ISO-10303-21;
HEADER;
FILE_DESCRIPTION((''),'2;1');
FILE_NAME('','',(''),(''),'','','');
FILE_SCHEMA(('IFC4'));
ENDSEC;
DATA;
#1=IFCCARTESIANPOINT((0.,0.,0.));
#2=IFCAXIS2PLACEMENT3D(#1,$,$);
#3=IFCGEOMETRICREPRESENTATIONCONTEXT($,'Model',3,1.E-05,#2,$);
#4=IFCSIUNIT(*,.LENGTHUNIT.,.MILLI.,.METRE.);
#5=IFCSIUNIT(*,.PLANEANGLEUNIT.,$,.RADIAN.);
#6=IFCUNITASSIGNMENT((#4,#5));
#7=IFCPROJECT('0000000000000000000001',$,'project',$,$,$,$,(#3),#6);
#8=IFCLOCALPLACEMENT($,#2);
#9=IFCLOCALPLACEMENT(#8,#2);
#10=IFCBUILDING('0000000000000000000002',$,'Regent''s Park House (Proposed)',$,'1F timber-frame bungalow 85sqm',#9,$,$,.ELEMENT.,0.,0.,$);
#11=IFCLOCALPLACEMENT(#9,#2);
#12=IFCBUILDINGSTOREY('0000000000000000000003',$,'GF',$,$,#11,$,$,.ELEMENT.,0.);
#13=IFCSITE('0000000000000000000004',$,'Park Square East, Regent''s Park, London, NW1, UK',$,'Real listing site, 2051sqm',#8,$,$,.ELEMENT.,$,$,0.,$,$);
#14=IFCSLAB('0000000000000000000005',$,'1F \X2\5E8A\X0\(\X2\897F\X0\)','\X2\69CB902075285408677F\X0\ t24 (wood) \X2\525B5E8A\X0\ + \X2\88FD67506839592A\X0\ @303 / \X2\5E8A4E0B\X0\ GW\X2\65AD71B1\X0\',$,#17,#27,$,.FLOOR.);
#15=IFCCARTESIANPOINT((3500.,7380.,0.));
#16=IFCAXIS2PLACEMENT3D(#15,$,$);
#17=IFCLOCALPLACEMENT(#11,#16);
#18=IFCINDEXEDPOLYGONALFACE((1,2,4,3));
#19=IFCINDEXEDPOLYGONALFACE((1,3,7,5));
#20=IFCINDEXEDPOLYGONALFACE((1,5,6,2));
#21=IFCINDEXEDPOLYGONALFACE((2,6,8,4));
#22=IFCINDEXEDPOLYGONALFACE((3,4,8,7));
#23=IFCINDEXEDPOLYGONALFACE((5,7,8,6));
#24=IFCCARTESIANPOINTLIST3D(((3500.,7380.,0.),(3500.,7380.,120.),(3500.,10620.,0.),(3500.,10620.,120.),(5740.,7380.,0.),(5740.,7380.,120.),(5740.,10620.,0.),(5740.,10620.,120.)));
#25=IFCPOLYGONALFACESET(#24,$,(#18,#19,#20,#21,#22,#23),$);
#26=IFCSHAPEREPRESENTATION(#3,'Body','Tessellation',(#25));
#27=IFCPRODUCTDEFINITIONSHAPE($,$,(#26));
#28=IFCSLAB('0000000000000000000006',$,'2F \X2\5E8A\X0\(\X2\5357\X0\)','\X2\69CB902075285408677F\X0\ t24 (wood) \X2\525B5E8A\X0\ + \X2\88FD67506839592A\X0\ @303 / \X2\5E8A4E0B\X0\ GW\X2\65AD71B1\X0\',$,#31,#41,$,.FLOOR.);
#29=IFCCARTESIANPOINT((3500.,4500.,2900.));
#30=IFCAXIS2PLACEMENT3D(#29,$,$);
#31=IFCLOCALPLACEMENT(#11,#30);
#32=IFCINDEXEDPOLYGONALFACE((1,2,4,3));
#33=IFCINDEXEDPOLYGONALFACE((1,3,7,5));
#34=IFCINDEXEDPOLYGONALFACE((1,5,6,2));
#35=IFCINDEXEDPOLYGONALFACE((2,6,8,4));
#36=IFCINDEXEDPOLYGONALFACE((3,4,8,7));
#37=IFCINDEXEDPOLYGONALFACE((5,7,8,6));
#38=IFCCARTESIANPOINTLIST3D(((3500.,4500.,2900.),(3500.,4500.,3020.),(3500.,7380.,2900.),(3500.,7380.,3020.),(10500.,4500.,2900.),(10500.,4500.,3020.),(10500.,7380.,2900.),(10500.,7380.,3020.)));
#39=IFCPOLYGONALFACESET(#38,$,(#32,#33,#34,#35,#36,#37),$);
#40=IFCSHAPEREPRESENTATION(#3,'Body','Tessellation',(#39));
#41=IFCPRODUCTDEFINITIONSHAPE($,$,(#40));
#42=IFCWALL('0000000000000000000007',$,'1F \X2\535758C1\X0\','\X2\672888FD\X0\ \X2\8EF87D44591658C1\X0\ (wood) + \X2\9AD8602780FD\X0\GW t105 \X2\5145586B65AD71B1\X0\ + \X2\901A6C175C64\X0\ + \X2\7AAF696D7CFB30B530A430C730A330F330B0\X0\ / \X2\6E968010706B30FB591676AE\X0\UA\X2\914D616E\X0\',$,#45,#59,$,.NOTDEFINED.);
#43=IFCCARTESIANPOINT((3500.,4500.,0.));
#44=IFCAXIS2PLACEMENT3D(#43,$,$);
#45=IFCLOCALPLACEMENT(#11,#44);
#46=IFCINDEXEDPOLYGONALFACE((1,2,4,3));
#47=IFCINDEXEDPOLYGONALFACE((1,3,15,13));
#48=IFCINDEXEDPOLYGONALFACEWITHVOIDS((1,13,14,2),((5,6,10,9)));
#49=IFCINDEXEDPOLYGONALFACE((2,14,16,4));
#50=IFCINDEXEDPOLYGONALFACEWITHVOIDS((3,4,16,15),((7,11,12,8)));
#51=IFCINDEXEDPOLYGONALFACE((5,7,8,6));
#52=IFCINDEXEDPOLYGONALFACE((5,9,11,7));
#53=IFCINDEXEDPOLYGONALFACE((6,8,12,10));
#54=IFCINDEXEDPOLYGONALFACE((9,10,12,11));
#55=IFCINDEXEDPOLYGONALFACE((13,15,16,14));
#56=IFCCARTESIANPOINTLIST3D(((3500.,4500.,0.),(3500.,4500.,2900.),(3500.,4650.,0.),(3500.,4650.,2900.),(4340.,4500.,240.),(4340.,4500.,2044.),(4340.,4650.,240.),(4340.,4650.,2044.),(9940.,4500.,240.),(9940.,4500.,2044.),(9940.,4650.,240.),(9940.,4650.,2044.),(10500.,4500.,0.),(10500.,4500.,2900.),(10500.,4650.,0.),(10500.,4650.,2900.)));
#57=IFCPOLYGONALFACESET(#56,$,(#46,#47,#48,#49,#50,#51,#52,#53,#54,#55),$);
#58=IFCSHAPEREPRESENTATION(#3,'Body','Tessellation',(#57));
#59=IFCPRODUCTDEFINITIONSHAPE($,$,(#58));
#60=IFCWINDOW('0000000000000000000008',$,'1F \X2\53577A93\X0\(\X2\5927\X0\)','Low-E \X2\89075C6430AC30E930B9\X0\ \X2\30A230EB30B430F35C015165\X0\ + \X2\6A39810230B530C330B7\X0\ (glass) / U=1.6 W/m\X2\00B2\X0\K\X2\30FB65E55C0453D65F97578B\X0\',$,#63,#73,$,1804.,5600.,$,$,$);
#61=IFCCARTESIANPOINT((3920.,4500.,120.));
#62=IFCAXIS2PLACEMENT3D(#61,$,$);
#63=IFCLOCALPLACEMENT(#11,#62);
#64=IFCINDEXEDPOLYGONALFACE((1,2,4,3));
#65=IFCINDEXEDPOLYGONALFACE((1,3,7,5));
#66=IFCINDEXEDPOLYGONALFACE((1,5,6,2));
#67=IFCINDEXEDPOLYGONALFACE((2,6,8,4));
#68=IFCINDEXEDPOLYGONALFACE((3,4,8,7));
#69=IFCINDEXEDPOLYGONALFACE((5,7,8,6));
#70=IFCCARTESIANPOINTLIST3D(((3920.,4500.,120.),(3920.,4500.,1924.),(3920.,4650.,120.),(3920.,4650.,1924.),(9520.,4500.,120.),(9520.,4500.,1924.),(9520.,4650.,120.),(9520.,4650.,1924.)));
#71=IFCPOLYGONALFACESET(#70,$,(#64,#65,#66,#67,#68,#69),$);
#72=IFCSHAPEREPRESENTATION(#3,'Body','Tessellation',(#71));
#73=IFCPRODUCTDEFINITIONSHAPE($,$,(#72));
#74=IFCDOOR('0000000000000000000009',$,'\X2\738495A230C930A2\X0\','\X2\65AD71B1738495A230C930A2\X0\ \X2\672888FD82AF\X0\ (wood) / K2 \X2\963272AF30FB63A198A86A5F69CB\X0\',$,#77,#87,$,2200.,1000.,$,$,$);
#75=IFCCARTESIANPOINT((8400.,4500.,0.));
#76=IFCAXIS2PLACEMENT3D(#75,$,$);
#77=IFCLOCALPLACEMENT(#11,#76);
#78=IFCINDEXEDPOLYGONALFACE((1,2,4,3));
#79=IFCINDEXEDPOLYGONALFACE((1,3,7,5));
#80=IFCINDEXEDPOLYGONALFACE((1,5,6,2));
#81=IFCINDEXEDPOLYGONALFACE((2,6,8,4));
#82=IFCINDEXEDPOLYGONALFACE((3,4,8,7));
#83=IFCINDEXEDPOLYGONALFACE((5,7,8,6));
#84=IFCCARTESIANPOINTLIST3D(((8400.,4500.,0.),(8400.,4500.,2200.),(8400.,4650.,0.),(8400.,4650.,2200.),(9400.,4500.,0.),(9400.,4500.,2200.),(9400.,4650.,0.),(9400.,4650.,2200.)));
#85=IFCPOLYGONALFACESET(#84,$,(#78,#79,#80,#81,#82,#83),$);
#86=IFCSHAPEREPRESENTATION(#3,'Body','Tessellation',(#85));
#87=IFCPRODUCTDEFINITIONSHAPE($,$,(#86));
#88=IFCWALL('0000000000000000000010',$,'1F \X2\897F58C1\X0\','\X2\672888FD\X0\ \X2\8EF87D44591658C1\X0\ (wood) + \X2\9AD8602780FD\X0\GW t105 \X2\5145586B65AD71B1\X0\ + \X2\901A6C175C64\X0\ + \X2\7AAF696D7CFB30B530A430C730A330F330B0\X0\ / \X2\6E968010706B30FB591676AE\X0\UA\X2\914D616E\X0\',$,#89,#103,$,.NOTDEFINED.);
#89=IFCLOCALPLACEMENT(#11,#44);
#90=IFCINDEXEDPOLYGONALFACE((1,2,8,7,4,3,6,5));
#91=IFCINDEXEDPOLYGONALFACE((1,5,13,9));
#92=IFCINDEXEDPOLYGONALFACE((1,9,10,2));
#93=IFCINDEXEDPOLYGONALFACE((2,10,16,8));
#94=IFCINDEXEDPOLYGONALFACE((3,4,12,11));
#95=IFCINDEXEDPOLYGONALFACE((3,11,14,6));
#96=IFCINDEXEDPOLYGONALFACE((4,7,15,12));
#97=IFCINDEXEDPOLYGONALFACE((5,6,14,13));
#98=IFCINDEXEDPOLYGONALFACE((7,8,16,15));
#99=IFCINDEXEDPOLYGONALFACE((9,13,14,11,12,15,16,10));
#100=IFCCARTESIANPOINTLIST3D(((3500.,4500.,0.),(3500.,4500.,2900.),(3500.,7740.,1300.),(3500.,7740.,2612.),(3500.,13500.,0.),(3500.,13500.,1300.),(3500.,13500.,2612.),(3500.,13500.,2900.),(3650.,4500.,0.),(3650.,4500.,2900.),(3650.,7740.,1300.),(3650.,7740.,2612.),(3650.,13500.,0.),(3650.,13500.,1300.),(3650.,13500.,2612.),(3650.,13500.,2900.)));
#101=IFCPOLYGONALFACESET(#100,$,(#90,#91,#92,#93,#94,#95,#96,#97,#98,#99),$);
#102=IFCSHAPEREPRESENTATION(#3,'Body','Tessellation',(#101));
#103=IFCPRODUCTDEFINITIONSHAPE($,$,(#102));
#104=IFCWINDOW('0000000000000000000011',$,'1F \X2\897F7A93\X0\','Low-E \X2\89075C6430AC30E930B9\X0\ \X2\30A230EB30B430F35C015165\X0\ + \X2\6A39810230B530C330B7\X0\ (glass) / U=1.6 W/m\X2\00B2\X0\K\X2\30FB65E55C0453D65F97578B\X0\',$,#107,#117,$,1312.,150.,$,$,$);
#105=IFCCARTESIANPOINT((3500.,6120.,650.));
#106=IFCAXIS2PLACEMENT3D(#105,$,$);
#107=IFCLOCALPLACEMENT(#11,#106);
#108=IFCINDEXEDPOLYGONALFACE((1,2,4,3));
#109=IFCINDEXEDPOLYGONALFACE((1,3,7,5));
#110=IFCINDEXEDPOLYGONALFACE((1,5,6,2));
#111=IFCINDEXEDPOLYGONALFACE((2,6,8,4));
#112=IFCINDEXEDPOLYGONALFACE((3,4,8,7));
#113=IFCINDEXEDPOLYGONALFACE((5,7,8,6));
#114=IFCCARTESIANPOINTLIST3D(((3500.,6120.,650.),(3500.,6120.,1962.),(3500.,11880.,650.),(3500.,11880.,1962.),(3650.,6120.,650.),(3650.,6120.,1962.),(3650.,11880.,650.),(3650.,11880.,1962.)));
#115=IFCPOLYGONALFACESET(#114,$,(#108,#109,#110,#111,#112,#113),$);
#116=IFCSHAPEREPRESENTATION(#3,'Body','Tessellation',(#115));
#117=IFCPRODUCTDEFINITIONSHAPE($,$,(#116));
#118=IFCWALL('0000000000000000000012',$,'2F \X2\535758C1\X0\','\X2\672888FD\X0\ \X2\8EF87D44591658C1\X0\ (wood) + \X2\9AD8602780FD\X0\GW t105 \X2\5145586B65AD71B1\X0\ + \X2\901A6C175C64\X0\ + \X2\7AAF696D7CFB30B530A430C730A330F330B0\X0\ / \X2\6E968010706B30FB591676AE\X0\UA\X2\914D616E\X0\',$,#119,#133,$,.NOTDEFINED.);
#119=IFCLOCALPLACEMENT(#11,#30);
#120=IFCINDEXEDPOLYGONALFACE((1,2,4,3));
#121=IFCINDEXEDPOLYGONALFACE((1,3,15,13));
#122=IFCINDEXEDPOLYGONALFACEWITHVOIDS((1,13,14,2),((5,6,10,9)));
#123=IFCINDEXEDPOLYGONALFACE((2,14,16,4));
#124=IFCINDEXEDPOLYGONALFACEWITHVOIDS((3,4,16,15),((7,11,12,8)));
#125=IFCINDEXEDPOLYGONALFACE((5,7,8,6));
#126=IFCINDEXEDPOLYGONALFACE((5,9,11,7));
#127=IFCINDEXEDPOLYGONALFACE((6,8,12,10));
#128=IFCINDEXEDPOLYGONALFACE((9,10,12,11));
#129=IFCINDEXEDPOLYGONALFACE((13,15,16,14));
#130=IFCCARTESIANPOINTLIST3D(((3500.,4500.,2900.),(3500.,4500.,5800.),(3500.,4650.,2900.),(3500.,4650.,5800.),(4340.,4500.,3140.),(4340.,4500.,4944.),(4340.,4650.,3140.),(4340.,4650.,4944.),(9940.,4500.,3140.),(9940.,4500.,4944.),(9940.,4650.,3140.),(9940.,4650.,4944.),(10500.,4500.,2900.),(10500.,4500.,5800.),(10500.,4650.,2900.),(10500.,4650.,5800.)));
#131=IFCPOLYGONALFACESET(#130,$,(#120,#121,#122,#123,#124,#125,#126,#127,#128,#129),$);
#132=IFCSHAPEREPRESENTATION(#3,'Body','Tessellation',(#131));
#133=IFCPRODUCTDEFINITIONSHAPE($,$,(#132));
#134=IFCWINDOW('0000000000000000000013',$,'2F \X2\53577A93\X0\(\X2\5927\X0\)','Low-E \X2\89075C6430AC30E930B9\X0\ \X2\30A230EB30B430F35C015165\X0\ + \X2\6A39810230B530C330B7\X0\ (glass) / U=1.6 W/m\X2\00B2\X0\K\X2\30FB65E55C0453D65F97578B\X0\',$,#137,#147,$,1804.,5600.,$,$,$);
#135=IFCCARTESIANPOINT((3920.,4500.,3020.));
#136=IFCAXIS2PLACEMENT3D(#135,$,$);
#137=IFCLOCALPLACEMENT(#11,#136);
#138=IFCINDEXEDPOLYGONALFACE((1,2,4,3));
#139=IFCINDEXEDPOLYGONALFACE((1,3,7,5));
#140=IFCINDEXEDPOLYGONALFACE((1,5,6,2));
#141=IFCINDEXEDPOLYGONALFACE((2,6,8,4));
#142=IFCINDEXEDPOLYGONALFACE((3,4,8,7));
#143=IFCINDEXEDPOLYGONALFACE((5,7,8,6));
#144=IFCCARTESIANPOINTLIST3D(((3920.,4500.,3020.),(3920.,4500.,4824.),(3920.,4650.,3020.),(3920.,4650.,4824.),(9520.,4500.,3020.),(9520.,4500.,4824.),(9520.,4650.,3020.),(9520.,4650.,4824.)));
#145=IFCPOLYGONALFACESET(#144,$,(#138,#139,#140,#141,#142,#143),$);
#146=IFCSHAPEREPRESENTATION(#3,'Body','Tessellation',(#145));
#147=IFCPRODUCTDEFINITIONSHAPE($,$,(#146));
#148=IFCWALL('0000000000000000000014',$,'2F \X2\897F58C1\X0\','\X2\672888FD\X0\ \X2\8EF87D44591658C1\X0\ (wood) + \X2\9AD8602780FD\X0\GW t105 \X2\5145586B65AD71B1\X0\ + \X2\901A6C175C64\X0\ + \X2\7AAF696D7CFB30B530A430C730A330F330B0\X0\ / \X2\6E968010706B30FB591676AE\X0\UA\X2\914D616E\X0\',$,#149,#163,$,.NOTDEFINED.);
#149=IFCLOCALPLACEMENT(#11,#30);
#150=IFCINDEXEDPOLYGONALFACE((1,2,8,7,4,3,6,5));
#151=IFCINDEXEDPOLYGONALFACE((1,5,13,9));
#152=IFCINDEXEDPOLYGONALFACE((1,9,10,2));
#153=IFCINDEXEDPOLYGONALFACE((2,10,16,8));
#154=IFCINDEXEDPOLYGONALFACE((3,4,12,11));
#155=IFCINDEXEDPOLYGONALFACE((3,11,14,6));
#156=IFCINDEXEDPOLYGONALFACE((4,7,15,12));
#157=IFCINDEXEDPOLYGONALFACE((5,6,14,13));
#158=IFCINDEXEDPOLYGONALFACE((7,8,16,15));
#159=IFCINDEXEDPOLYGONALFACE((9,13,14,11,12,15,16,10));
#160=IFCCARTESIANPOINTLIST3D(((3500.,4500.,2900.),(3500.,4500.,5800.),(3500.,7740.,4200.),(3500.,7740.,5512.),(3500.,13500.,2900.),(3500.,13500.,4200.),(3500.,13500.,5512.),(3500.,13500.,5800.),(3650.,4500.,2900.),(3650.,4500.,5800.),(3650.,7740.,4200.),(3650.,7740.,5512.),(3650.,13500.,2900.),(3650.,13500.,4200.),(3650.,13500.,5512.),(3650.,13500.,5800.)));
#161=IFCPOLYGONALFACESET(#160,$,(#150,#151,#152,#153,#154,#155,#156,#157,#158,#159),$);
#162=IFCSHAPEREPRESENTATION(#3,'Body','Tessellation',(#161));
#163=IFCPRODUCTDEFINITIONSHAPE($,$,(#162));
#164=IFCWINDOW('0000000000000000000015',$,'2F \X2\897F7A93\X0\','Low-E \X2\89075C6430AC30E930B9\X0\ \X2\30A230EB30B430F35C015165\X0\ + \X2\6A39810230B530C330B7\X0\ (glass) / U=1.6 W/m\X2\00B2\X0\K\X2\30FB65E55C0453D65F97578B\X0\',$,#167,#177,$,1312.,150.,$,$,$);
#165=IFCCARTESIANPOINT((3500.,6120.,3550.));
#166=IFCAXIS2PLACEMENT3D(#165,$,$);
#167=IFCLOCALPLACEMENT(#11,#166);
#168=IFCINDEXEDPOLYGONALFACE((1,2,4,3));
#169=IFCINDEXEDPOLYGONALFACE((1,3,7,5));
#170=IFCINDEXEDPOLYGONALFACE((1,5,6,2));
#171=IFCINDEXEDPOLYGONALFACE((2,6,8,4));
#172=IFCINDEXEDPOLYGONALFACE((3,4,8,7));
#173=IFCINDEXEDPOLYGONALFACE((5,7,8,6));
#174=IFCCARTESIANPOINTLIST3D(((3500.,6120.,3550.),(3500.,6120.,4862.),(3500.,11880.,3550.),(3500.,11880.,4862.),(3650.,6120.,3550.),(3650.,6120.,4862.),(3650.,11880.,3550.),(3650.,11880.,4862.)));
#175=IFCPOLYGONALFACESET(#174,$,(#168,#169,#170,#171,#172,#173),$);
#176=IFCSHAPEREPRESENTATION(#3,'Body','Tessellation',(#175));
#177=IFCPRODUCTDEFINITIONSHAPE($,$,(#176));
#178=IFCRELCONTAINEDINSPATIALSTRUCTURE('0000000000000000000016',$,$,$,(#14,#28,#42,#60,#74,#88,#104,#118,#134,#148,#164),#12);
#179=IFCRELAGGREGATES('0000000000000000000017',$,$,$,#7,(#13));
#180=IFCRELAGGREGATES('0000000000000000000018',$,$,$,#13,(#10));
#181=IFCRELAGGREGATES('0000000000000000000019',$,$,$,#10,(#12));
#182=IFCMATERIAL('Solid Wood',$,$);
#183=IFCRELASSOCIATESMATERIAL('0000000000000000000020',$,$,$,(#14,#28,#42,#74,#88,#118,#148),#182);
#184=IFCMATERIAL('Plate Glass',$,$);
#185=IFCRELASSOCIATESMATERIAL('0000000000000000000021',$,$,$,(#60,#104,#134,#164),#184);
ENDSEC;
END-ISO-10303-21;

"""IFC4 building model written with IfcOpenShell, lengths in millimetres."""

from ifc_helpers import new_model, si_unit, frame, frame_2d, origin, place, context, project, spatial, rectangle, extrude, material, element, fill, save


model = new_model("IFC4")

# Units and contexts
model_context = context("Model", 3, precision=1e-05, world=origin())
ifc_project = project(units=[si_unit("LENGTHUNIT", "METRE", prefix="MILLI"), si_unit("PLANEANGLEUNIT", "RADIAN")], contexts=[model_context])

# Site, building, storey
site_placement = place(None, origin())
site = spatial("IfcSite", under=ifc_project, at=site_placement, Name="Park Square East, Regent's Park, London, NW1, UK", ObjectType="Real listing site, 2051sqm", CompositionType="ELEMENT", RefElevation=0.0)
building_placement = place(site_placement, origin())
building = spatial("IfcBuilding", under=site, at=building_placement, Name="Regent's Park House (Proposed)", ObjectType="1F timber-frame bungalow 85sqm", CompositionType="ELEMENT", ElevationOfRefHeight=0.0, ElevationOfTerrain=0.0)
storey_placement = place(building_placement, origin())
storey = spatial("IfcBuildingStorey", under=building, at=storey_placement, Name="GF", CompositionType="ELEMENT", Elevation=0.0)

# Slabs
ifc_material_1 = material(Name="Solid Wood")
slab_1_placement = place(storey_placement, frame((3500.0, 7380.0, 0.0)))
element("IfcSlab", 1, at=slab_1_placement, inside=storey, material=ifc_material_1, Name="1F 床(西)", Description="構造用合板 t24 (wood) 剛床 + 製材根太 @303 / 床下 GW断熱", PredefinedType="FLOOR", context=model_context, shape_type="SweptSolid", body=[
    extrude(rectangle(XDim=2240.0, YDim=3240.0, at=frame_2d((1120.0, 1620.0))), frame((3500.0, 7380.0, 0.0)), (0.0, 0.0, 1.0), 120.0),
])
slab_2_placement = place(storey_placement, frame((3500.0, 4500.0, 2900.0)))
element("IfcSlab", 2, at=slab_2_placement, inside=storey, material=ifc_material_1, Name="2F 床(南)", Description="構造用合板 t24 (wood) 剛床 + 製材根太 @303 / 床下 GW断熱", PredefinedType="FLOOR", context=model_context, shape_type="SweptSolid", body=[
    extrude(rectangle(XDim=7000.0, YDim=2880.0, at=frame_2d((3500.0, 1440.0))), frame((3500.0, 4500.0, 2900.0)), (0.0, 0.0, 1.0), 120.0),
])

# Wall, openings, window, door
wall_1_placement = place(storey_placement, frame((3500.0, 4500.0, 0.0)))
wall_1 = element("IfcWall", 3, at=wall_1_placement, inside=storey, material=ifc_material_1, Name="1F 南壁", Description="木製 軸組外壁 (wood) + 高性能GW t105 充填断熱 + 通気層 + 窯業系サイディング / 準耐火・外皮UA配慮", PredefinedType="NOTDEFINED", context=model_context, shape_type="SweptSolid", body=[
    extrude(rectangle(XDim=7000.0, YDim=150.0, at=frame_2d((3500.0, 75.0))), frame((3500.0, 4500.0, 0.0)), (0.0, 0.0, 1.0), 2900.0),
])
opening_1_placement = place(storey_placement, frame((3920.0, 4500.0, 120.0)))
opening_1 = element("IfcOpeningElement", 4, at=opening_1_placement, cuts=wall_1, PredefinedType="NOTDEFINED", context=model_context, shape_type="SweptSolid", body=[
    extrude(rectangle(XDim=5600.0, YDim=150.0, at=frame_2d((2800.0, 75.0))), frame((3920.0, 4500.0, 120.0)), (0.0, 0.0, 1.0), 1804.0),
])
opening_2_placement = place(storey_placement, frame((8400.0, 4500.0, 0.0)))
opening_2 = element("IfcOpeningElement", 5, at=opening_2_placement, cuts=wall_1, PredefinedType="NOTDEFINED", context=model_context, shape_type="SweptSolid", body=[
    extrude(rectangle(XDim=1000.0, YDim=150.0, at=frame_2d((500.0, 75.0))), frame((8400.0, 4500.0, 0.0)), (0.0, 0.0, 1.0), 2200.0),
])
ifc_material_2 = material(Name="Plate Glass")
window_1_placement = place(storey_placement, frame((3920.0, 4500.0, 120.0)))
window_1 = element("IfcWindow", 6, at=window_1_placement, inside=storey, material=ifc_material_2, Name="1F 南窓(大)", Description="Low-E 複層ガラス アルゴン封入 + 樹脂サッシ (glass) / U=1.6 W/m²K・日射取得型", OverallHeight=1804.0, OverallWidth=5600.0, context=model_context, shape_type="SweptSolid", body=[
    extrude(rectangle(XDim=5600.0, YDim=150.0, at=frame_2d((2800.0, 75.0))), frame((3920.0, 4500.0, 120.0)), (0.0, 0.0, 1.0), 1804.0),
])
fill(opening_1, window_1)
door_placement = place(storey_placement, frame((8400.0, 4500.0, 0.0)))
door = element("IfcDoor", 7, at=door_placement, inside=storey, material=ifc_material_1, Name="玄関ドア", Description="断熱玄関ドア 木製芯 (wood) / K2 防犯・採風機構", OverallHeight=2200.0, OverallWidth=1000.0, context=model_context, shape_type="SweptSolid", body=[
    extrude(rectangle(XDim=1000.0, YDim=150.0, at=frame_2d((500.0, 75.0))), frame((8400.0, 4500.0, 0.0)), (0.0, 0.0, 1.0), 2200.0),
])
fill(opening_2, door)

# Walls, openings, windows
wall_2_placement = place(storey_placement, frame((3500.0, 4500.0, 0.0)))
wall_2 = element("IfcWall", 8, at=wall_2_placement, inside=storey, material=ifc_material_1, Name="1F 西壁", Description="木製 軸組外壁 (wood) + 高性能GW t105 充填断熱 + 通気層 + 窯業系サイディング / 準耐火・外皮UA配慮", PredefinedType="NOTDEFINED", context=model_context, shape_type="SweptSolid", body=[
    extrude(rectangle(XDim=150.0, YDim=9000.0, at=frame_2d((75.0, 4500.0))), frame((3500.0, 4500.0, 0.0)), (0.0, 0.0, 1.0), 2900.0),
])
opening_3_placement = place(storey_placement, frame((3500.0, 6120.0, 650.0)))
opening_3 = element("IfcOpeningElement", 9, at=opening_3_placement, cuts=wall_2, PredefinedType="NOTDEFINED", context=model_context, shape_type="SweptSolid", body=[
    extrude(rectangle(XDim=150.0, YDim=5760.0, at=frame_2d((75.0, 2880.0))), frame((3500.0, 6120.0, 650.0)), (0.0, 0.0, 1.0), 1312.0),
])
window_2_placement = place(storey_placement, frame((3500.0, 6120.0, 650.0)))
window_2 = element("IfcWindow", 10, at=window_2_placement, inside=storey, material=ifc_material_2, Name="1F 西窓", Description="Low-E 複層ガラス アルゴン封入 + 樹脂サッシ (glass) / U=1.6 W/m²K・日射取得型", OverallHeight=1312.0, OverallWidth=150.0, context=model_context, shape_type="SweptSolid", body=[
    extrude(rectangle(XDim=150.0, YDim=5760.0, at=frame_2d((75.0, 2880.0))), frame((3500.0, 6120.0, 650.0)), (0.0, 0.0, 1.0), 1312.0),
])
fill(opening_3, window_2)
wall_3_placement = place(storey_placement, frame((3500.0, 4500.0, 2900.0)))
wall_3 = element("IfcWall", 11, at=wall_3_placement, inside=storey, material=ifc_material_1, Name="2F 南壁", Description="木製 軸組外壁 (wood) + 高性能GW t105 充填断熱 + 通気層 + 窯業系サイディング / 準耐火・外皮UA配慮", PredefinedType="NOTDEFINED", context=model_context, shape_type="SweptSolid", body=[
    extrude(rectangle(XDim=7000.0, YDim=150.0, at=frame_2d((3500.0, 75.0))), frame((3500.0, 4500.0, 2900.0)), (0.0, 0.0, 1.0), 2900.0),
])
opening_4_placement = place(storey_placement, frame((3920.0, 4500.0, 3020.0)))
opening_4 = element("IfcOpeningElement", 12, at=opening_4_placement, cuts=wall_3, PredefinedType="NOTDEFINED", context=model_context, shape_type="SweptSolid", body=[
    extrude(rectangle(XDim=5600.0, YDim=150.0, at=frame_2d((2800.0, 75.0))), frame((3920.0, 4500.0, 3020.0)), (0.0, 0.0, 1.0), 1804.0),
])
window_3_placement = place(storey_placement, frame((3920.0, 4500.0, 3020.0)))
window_3 = element("IfcWindow", 13, at=window_3_placement, inside=storey, material=ifc_material_2, Name="2F 南窓(大)", Description="Low-E 複層ガラス アルゴン封入 + 樹脂サッシ (glass) / U=1.6 W/m²K・日射取得型", OverallHeight=1804.0, OverallWidth=5600.0, context=model_context, shape_type="SweptSolid", body=[
    extrude(rectangle(XDim=5600.0, YDim=150.0, at=frame_2d((2800.0, 75.0))), frame((3920.0, 4500.0, 3020.0)), (0.0, 0.0, 1.0), 1804.0),
])
fill(opening_4, window_3)
wall_4_placement = place(storey_placement, frame((3500.0, 4500.0, 2900.0)))
wall_4 = element("IfcWall", 14, at=wall_4_placement, inside=storey, material=ifc_material_1, Name="2F 西壁", Description="木製 軸組外壁 (wood) + 高性能GW t105 充填断熱 + 通気層 + 窯業系サイディング / 準耐火・外皮UA配慮", PredefinedType="NOTDEFINED", context=model_context, shape_type="SweptSolid", body=[
    extrude(rectangle(XDim=150.0, YDim=9000.0, at=frame_2d((75.0, 4500.0))), frame((3500.0, 4500.0, 2900.0)), (0.0, 0.0, 1.0), 2900.0),
])
opening_5_placement = place(storey_placement, frame((3500.0, 6120.0, 3550.0)))
opening_5 = element("IfcOpeningElement", 15, at=opening_5_placement, cuts=wall_4, PredefinedType="NOTDEFINED", context=model_context, shape_type="SweptSolid", body=[
    extrude(rectangle(XDim=150.0, YDim=5760.0, at=frame_2d((75.0, 2880.0))), frame((3500.0, 6120.0, 3550.0)), (0.0, 0.0, 1.0), 1312.0),
])
window_4_placement = place(storey_placement, frame((3500.0, 6120.0, 3550.0)))
window_4 = element("IfcWindow", 16, at=window_4_placement, inside=storey, material=ifc_material_2, Name="2F 西窓", Description="Low-E 複層ガラス アルゴン封入 + 樹脂サッシ (glass) / U=1.6 W/m²K・日射取得型", OverallHeight=1312.0, OverallWidth=150.0, context=model_context, shape_type="SweptSolid", body=[
    extrude(rectangle(XDim=150.0, YDim=5760.0, at=frame_2d((75.0, 2880.0))), frame((3500.0, 6120.0, 3550.0)), (0.0, 0.0, 1.0), 1312.0),
])
fill(opening_5, window_4)

save(model, "model.ifc")
